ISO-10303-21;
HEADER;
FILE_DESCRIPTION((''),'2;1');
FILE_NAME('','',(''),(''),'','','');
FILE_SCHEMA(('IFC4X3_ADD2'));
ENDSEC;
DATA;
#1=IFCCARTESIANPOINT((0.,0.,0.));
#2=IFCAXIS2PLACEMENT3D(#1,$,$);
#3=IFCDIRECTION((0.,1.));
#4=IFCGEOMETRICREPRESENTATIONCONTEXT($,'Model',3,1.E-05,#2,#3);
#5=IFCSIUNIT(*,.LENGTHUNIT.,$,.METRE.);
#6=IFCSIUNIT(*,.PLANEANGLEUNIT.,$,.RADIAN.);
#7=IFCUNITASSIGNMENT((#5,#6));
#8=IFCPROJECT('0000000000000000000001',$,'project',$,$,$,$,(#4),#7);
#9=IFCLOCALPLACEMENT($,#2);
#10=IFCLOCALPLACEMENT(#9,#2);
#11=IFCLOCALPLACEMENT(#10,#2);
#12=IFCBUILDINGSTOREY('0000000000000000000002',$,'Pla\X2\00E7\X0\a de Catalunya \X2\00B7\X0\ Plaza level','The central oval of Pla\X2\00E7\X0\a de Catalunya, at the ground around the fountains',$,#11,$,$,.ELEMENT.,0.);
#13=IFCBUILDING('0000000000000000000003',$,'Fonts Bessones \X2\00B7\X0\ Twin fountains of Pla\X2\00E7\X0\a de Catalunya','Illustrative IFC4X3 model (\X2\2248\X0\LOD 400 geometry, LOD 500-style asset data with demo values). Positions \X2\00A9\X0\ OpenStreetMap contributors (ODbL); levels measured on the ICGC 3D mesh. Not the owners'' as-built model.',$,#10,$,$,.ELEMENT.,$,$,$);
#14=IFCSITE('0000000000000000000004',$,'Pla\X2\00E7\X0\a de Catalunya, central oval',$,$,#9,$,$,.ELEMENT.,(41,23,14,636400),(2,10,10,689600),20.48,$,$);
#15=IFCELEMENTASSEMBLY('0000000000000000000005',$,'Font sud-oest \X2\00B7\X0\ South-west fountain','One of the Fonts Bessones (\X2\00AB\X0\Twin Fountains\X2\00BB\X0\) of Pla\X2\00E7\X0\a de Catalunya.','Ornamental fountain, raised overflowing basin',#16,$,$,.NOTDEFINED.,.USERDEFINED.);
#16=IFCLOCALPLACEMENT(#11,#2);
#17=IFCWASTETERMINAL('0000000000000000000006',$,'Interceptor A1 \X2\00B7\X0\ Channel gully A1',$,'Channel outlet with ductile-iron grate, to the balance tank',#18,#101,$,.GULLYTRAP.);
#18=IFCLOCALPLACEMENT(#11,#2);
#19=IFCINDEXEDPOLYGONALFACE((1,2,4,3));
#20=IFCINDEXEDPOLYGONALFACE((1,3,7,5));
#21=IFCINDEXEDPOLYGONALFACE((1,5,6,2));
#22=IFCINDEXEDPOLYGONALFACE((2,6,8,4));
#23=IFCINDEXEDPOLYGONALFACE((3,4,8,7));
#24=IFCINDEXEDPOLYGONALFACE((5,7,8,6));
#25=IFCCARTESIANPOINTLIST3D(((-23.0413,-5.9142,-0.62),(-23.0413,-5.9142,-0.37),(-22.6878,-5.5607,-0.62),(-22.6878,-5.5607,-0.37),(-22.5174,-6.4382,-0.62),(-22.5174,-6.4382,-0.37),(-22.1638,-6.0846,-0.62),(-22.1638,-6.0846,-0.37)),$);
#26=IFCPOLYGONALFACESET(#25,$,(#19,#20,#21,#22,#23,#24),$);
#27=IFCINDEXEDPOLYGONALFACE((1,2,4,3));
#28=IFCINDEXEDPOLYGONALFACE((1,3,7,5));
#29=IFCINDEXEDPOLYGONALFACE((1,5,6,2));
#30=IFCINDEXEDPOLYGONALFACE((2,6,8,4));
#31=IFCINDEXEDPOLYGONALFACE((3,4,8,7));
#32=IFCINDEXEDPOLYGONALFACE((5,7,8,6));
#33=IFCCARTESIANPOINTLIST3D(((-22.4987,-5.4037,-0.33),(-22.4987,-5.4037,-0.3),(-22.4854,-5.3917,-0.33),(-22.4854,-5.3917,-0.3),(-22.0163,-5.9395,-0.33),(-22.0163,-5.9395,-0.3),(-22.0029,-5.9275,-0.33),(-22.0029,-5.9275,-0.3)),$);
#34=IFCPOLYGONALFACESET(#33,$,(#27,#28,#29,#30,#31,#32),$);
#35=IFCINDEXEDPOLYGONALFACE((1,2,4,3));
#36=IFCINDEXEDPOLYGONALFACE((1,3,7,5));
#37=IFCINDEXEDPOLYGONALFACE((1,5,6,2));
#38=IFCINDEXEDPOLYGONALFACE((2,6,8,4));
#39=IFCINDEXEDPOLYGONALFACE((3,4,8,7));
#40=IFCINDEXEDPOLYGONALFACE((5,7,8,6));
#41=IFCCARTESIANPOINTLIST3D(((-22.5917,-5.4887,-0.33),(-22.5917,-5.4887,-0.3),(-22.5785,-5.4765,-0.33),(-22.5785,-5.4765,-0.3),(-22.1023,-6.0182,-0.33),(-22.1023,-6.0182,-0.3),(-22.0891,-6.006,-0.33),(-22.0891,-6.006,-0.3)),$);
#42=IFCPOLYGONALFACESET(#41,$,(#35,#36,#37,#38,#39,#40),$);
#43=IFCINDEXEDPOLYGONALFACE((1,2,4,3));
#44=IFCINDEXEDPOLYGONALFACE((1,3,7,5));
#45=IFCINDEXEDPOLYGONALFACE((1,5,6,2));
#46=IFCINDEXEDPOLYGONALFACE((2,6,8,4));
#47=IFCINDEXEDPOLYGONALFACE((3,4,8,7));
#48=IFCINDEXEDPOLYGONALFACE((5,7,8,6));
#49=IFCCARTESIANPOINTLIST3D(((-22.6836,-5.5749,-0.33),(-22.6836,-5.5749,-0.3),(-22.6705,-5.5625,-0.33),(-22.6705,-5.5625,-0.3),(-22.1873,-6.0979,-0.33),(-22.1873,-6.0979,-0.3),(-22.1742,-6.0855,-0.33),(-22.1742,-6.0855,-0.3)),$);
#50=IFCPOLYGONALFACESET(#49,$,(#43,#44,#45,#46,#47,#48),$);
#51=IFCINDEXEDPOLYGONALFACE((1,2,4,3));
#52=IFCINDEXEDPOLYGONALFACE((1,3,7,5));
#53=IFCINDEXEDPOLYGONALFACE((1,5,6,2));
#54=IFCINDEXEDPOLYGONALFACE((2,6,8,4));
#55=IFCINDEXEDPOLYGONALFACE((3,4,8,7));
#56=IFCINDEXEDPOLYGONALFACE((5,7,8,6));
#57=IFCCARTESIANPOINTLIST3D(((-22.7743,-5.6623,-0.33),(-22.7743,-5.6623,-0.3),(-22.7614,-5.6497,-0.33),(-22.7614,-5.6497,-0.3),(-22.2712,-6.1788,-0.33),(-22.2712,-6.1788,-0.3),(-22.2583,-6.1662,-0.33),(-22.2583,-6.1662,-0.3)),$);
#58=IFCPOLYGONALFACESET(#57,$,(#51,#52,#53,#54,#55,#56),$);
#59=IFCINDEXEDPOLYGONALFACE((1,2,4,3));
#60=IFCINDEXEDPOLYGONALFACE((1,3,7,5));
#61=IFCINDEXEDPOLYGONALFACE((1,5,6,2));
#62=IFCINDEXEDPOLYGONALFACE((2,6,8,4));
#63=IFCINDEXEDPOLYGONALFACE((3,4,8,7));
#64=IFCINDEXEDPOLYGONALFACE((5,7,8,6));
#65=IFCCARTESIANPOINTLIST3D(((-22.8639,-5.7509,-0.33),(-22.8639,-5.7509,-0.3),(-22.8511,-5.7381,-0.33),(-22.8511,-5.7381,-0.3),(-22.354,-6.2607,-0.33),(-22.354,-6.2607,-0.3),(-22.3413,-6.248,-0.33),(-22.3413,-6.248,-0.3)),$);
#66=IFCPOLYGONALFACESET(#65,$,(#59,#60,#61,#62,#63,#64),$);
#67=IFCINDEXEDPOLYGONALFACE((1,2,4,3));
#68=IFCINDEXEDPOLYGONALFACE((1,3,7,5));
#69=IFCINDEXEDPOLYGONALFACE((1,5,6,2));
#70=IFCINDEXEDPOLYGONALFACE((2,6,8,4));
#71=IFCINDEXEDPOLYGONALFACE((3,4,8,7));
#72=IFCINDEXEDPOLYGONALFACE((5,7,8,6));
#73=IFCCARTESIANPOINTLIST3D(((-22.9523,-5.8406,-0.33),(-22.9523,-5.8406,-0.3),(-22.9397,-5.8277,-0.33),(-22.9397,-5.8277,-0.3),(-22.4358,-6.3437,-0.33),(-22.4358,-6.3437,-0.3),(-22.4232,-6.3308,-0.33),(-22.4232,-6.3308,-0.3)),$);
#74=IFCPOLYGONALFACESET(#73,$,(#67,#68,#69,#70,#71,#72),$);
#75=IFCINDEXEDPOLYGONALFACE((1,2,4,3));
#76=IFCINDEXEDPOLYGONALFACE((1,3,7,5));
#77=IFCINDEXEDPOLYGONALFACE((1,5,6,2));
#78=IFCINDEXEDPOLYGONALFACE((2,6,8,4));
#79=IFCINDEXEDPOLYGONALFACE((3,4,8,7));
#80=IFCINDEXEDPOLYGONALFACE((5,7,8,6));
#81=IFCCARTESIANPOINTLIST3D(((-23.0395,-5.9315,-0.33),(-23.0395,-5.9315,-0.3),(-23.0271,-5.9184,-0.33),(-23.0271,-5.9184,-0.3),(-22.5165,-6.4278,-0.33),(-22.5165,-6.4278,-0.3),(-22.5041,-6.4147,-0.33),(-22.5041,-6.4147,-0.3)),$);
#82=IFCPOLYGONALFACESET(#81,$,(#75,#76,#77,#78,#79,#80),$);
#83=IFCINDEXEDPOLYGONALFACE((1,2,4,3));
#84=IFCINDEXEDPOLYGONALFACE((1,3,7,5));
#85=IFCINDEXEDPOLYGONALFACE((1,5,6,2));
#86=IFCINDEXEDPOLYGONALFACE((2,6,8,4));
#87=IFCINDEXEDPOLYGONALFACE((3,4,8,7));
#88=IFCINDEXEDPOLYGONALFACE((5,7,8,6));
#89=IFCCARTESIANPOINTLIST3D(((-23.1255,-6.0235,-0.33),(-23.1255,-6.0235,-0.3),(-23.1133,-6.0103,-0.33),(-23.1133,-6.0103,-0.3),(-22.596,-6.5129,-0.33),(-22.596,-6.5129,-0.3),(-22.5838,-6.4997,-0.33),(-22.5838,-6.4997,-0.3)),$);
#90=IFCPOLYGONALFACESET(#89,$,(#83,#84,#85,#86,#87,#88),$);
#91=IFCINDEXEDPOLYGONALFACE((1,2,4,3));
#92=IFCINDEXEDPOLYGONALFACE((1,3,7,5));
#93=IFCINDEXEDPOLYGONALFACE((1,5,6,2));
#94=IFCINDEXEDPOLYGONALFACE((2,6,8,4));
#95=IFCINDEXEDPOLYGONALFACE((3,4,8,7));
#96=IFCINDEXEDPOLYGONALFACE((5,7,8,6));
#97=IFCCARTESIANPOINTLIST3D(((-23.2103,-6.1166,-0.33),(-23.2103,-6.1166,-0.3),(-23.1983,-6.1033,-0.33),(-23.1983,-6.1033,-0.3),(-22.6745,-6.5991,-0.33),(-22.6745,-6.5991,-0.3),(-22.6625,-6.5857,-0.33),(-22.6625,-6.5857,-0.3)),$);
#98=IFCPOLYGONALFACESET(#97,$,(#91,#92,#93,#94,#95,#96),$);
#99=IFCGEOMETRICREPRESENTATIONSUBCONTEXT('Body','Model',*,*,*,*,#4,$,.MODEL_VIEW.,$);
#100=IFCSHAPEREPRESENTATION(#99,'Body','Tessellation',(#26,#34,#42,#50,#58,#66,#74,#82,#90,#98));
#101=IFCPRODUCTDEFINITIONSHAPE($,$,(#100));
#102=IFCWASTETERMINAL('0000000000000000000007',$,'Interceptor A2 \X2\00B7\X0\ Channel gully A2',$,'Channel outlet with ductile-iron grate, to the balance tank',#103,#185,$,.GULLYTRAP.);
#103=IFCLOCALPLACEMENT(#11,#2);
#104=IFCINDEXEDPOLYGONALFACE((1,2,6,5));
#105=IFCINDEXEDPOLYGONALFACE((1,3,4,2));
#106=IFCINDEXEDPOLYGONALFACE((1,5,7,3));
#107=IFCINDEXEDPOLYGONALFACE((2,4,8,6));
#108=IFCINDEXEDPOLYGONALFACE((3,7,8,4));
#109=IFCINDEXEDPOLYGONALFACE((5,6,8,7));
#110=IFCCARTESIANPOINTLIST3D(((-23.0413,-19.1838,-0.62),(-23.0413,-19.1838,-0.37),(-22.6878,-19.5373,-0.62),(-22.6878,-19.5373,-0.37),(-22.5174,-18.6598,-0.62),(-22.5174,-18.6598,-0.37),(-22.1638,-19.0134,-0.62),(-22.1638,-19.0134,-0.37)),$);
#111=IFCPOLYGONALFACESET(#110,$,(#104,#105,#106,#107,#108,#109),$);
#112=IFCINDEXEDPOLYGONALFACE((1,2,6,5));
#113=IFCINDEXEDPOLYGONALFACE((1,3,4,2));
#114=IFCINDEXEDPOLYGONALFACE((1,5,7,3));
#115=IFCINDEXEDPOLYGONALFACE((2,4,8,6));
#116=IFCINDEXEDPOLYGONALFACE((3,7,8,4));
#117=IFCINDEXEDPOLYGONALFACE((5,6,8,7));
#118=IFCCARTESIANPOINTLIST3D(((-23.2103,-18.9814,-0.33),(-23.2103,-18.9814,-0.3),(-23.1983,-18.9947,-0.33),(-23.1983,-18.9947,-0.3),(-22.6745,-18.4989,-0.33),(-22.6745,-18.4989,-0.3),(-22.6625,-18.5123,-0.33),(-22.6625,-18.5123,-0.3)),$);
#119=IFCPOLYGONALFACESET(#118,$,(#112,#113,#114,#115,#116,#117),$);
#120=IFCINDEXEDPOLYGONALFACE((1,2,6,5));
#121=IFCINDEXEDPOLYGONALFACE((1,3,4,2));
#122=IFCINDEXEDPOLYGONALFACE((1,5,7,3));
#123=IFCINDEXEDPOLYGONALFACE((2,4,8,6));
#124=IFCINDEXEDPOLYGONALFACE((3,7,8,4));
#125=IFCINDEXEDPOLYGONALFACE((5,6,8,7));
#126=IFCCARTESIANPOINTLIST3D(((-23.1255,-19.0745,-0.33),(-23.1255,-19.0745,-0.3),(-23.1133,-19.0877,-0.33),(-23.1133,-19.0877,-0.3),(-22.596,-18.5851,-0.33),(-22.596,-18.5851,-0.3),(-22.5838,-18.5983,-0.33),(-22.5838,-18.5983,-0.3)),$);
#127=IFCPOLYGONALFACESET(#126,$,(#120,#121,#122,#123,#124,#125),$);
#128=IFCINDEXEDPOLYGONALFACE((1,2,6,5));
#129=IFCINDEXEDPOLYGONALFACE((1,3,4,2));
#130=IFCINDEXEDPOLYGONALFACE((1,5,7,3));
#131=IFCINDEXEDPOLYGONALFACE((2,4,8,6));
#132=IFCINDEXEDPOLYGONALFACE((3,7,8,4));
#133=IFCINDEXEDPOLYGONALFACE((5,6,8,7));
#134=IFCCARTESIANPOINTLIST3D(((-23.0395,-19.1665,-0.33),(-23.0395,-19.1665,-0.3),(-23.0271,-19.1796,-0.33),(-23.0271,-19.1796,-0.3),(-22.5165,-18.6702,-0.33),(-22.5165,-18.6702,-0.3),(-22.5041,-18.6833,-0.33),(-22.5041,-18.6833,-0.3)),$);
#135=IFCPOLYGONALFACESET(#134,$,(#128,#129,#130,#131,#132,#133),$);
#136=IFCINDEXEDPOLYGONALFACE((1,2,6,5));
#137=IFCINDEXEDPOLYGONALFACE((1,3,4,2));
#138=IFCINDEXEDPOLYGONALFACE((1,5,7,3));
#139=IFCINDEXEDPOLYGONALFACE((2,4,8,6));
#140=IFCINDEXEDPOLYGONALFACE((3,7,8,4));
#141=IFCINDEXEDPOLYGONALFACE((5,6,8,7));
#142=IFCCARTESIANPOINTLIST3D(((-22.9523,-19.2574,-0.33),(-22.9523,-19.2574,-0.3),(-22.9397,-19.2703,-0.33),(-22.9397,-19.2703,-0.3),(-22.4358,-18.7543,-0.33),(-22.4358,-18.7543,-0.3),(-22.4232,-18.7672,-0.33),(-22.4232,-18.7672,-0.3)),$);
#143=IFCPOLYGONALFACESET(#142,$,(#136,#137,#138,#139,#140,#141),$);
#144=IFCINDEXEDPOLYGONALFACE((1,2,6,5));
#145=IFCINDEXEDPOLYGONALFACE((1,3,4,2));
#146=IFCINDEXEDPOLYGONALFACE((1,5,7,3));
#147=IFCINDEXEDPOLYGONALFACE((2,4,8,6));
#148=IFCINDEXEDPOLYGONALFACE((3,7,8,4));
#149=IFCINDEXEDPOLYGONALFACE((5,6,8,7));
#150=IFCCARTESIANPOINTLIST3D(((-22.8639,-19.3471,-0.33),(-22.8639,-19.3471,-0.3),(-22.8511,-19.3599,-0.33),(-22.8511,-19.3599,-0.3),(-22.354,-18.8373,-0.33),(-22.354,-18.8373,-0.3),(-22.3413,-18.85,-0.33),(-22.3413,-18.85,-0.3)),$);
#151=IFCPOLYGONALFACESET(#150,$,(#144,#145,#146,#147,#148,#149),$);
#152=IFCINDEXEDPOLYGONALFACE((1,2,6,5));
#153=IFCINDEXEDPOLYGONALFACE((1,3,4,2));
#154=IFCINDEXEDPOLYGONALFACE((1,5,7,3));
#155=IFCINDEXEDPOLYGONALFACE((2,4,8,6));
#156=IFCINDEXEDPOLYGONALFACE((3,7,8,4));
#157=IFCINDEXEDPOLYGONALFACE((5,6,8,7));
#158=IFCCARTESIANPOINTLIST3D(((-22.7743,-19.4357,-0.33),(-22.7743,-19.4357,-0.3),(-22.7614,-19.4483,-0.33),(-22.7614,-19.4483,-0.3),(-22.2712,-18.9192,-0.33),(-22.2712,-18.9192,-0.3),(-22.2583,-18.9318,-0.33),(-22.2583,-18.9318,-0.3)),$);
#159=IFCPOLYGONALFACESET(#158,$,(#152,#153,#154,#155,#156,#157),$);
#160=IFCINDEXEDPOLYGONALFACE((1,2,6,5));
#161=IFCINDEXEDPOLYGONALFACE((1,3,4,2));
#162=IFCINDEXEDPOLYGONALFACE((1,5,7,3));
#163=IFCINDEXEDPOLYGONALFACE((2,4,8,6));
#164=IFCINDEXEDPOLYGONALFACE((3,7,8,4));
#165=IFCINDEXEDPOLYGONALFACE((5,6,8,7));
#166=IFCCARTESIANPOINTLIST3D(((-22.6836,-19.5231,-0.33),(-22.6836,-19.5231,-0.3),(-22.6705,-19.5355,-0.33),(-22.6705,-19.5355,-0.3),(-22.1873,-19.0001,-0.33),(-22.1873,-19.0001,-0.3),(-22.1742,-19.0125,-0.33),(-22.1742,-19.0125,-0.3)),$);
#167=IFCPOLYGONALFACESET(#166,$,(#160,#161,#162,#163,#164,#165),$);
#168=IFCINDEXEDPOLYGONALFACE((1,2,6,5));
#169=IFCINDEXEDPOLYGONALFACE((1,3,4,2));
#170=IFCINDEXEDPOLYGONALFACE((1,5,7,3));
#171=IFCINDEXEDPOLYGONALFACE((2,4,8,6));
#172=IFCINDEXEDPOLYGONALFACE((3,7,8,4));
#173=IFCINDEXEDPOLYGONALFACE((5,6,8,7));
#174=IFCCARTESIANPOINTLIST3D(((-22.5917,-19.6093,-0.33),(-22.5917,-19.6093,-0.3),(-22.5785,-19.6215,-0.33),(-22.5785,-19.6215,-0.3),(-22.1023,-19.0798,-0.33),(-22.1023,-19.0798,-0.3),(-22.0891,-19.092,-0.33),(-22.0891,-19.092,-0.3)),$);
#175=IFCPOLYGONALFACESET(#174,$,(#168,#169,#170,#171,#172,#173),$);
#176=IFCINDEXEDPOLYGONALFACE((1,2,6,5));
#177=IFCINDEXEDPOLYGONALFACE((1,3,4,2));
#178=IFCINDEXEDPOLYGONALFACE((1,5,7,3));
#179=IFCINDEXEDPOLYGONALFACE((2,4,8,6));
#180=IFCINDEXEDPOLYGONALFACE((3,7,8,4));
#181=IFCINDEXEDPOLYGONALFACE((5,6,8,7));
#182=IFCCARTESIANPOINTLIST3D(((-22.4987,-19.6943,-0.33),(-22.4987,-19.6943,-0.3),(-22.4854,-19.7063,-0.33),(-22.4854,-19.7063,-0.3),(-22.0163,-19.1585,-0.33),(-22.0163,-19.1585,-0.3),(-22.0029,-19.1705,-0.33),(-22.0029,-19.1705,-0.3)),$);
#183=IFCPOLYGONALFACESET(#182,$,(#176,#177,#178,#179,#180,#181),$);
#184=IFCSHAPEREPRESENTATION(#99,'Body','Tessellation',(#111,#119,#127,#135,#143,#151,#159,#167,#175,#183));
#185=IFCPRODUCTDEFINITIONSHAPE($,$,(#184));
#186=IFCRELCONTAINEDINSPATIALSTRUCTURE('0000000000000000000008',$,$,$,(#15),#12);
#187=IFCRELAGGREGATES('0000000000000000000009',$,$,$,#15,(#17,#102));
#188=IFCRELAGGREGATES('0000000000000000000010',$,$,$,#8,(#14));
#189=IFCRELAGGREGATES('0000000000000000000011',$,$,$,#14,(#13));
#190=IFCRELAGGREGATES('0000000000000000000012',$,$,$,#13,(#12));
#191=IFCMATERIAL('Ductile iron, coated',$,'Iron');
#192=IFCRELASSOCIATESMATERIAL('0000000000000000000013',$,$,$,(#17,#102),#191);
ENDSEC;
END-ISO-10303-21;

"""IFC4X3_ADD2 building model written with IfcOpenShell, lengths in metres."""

from ifc_helpers import new_model, si_unit, direction, frame, frame_2d, origin, place, context, subcontext, project, spatial, rectangle, extrude, material, element, aggregate, save


model = new_model("IFC4X3_ADD2")

# Units and contexts
model_context = context("Model", 3, precision=1e-05, world=origin(), true_north=direction((0.0, 1.0)))
body_context = subcontext(model_context, "Body", "Model", "MODEL_VIEW")
ifc_project = project(units=[si_unit("LENGTHUNIT", "METRE"), si_unit("PLANEANGLEUNIT", "RADIAN")], contexts=[model_context])

# Site, building, storey
site_placement = place(None, origin())
site = spatial("IfcSite", under=ifc_project, at=site_placement, Name="Plaça de Catalunya, central oval", CompositionType="ELEMENT", RefLatitude=(41, 23, 14, 636400), RefLongitude=(2, 10, 10, 689600), RefElevation=20.48)
building_placement = place(site_placement, origin())
building = spatial("IfcBuilding", under=site, at=building_placement, Name="Fonts Bessones · Twin fountains of Plaça de Catalunya", Description="Illustrative IFC4X3 model (≈LOD 400 geometry, LOD 500-style asset data with demo values). Positions © OpenStreetMap contributors (ODbL); levels measured on the ICGC 3D mesh. Not the owners' as-built model.", CompositionType="ELEMENT")
storey_placement = place(building_placement, origin())
storey = spatial("IfcBuildingStorey", under=building, at=storey_placement, Name="Plaça de Catalunya · Plaza level", Description="The central oval of Plaça de Catalunya, at the ground around the fountains", CompositionType="ELEMENT", Elevation=0.0)

# Element assembly, waste terminals
assembly_1_placement = place(building_placement, origin())
assembly_1 = element("IfcElementAssembly", 1, at=assembly_1_placement, inside=storey, Name="Font sud-oest · South-west fountain", Description="One of the Fonts Bessones («Twin Fountains») of Plaça de Catalunya.", ObjectType="Ornamental fountain, raised overflowing basin", AssemblyPlace="NOTDEFINED", PredefinedType="USERDEFINED")
ifc_material_1 = material(Name="Ductile iron, coated", Category="Iron")
waste_terminal_1_placement = place(building_placement, origin())
waste_terminal_1 = element("IfcWasteTerminal", 2, at=waste_terminal_1_placement, material=ifc_material_1, Name="Interceptor A1 · Channel gully A1", ObjectType="Channel outlet with ductile-iron grate, to the balance tank", PredefinedType="GULLYTRAP", context=body_context, shape_type="SweptSolid", body=[
    extrude(rectangle(XDim=0.741, YDim=0.5, at=frame_2d((0.0, 0.0), x_axis=(-0.707107, 0.707107))), frame((-22.6026, -5.9994, -0.62)), (0.0, 0.0, 1.0), 0.25),
    extrude(rectangle(XDim=0.721, YDim=0.018, at=frame_2d((0.0, 0.0), x_axis=(-0.669131, 0.743145))), frame((-22.2508, -5.6656, -0.33)), (0.0, 0.0, 1.0), 0.03),
    extrude(rectangle(XDim=0.721, YDim=0.018, at=frame_2d((0.0, 0.0), x_axis=(-0.678801, 0.734323))), frame((-22.3404, -5.7473, -0.33)), (0.0, 0.0, 1.0), 0.03),
    extrude(rectangle(XDim=0.721, YDim=0.018, at=frame_2d((0.0, 0.0), x_axis=(-0.688355, 0.725374))), frame((-22.4289, -5.8302, -0.33)), (0.0, 0.0, 1.0), 0.03),
    extrude(rectangle(XDim=0.721, YDim=0.018, at=frame_2d((0.0, 0.0), x_axis=(-0.69779, 0.716302))), frame((-22.5163, -5.9143, -0.33)), (0.0, 0.0, 1.0), 0.03),
    extrude(rectangle(XDim=0.721, YDim=0.018, at=frame_2d((0.0, 0.0), x_axis=(-0.707107, 0.707107))), frame((-22.6026, -5.9994, -0.33)), (0.0, 0.0, 1.0), 0.03),
    extrude(rectangle(XDim=0.721, YDim=0.018, at=frame_2d((0.0, 0.0), x_axis=(-0.716302, 0.69779))), frame((-22.6877, -6.0857, -0.33)), (0.0, 0.0, 1.0), 0.03),
    extrude(rectangle(XDim=0.721, YDim=0.018, at=frame_2d((0.0, 0.0), x_axis=(-0.725374, 0.688355))), frame((-22.7718, -6.1731, -0.33)), (0.0, 0.0, 1.0), 0.03),
    extrude(rectangle(XDim=0.721, YDim=0.018, at=frame_2d((0.0, 0.0), x_axis=(-0.734323, 0.678801))), frame((-22.8547, -6.2616, -0.33)), (0.0, 0.0, 1.0), 0.03),
    extrude(rectangle(XDim=0.721, YDim=0.018, at=frame_2d((0.0, 0.0), x_axis=(-0.743145, 0.669131))), frame((-22.9364, -6.3512, -0.33)), (0.0, 0.0, 1.0), 0.03),
])
waste_terminal_2_placement = place(building_placement, origin())
waste_terminal_2 = element("IfcWasteTerminal", 3, at=waste_terminal_2_placement, material=ifc_material_1, Name="Interceptor A2 · Channel gully A2", ObjectType="Channel outlet with ductile-iron grate, to the balance tank", PredefinedType="GULLYTRAP", context=body_context, shape_type="SweptSolid", body=[
    extrude(rectangle(XDim=0.741, YDim=0.5, at=frame_2d((0.0, 0.0), x_axis=(-0.707107, -0.707107))), frame((-22.6026, -19.0986, -0.62)), (0.0, 0.0, 1.0), 0.25),
    extrude(rectangle(XDim=0.721, YDim=0.018, at=frame_2d((0.0, 0.0), x_axis=(-0.743145, -0.669131))), frame((-22.9364, -18.7468, -0.33)), (0.0, 0.0, 1.0), 0.03),
    extrude(rectangle(XDim=0.721, YDim=0.018, at=frame_2d((0.0, 0.0), x_axis=(-0.734323, -0.678801))), frame((-22.8547, -18.8364, -0.33)), (0.0, 0.0, 1.0), 0.03),
    extrude(rectangle(XDim=0.721, YDim=0.018, at=frame_2d((0.0, 0.0), x_axis=(-0.725374, -0.688355))), frame((-22.7718, -18.9249, -0.33)), (0.0, 0.0, 1.0), 0.03),
    extrude(rectangle(XDim=0.721, YDim=0.018, at=frame_2d((0.0, 0.0), x_axis=(-0.716302, -0.69779))), frame((-22.6877, -19.0123, -0.33)), (0.0, 0.0, 1.0), 0.03),
    extrude(rectangle(XDim=0.721, YDim=0.018, at=frame_2d((0.0, 0.0), x_axis=(-0.707107, -0.707107))), frame((-22.6026, -19.0986, -0.33)), (0.0, 0.0, 1.0), 0.03),
    extrude(rectangle(XDim=0.721, YDim=0.018, at=frame_2d((0.0, 0.0), x_axis=(-0.69779, -0.716302))), frame((-22.5163, -19.1837, -0.33)), (0.0, 0.0, 1.0), 0.03),
    extrude(rectangle(XDim=0.721, YDim=0.018, at=frame_2d((0.0, 0.0), x_axis=(-0.688355, -0.725374))), frame((-22.4289, -19.2678, -0.33)), (0.0, 0.0, 1.0), 0.03),
    extrude(rectangle(XDim=0.721, YDim=0.018, at=frame_2d((0.0, 0.0), x_axis=(-0.678801, -0.734323))), frame((-22.3404, -19.3507, -0.33)), (0.0, 0.0, 1.0), 0.03),
    extrude(rectangle(XDim=0.721, YDim=0.018, at=frame_2d((0.0, 0.0), x_axis=(-0.669131, -0.743145))), frame((-22.2508, -19.4324, -0.33)), (0.0, 0.0, 1.0), 0.03),
])
aggregate(assembly_1, [waste_terminal_1, waste_terminal_2])

save(model, "model.ifc")
